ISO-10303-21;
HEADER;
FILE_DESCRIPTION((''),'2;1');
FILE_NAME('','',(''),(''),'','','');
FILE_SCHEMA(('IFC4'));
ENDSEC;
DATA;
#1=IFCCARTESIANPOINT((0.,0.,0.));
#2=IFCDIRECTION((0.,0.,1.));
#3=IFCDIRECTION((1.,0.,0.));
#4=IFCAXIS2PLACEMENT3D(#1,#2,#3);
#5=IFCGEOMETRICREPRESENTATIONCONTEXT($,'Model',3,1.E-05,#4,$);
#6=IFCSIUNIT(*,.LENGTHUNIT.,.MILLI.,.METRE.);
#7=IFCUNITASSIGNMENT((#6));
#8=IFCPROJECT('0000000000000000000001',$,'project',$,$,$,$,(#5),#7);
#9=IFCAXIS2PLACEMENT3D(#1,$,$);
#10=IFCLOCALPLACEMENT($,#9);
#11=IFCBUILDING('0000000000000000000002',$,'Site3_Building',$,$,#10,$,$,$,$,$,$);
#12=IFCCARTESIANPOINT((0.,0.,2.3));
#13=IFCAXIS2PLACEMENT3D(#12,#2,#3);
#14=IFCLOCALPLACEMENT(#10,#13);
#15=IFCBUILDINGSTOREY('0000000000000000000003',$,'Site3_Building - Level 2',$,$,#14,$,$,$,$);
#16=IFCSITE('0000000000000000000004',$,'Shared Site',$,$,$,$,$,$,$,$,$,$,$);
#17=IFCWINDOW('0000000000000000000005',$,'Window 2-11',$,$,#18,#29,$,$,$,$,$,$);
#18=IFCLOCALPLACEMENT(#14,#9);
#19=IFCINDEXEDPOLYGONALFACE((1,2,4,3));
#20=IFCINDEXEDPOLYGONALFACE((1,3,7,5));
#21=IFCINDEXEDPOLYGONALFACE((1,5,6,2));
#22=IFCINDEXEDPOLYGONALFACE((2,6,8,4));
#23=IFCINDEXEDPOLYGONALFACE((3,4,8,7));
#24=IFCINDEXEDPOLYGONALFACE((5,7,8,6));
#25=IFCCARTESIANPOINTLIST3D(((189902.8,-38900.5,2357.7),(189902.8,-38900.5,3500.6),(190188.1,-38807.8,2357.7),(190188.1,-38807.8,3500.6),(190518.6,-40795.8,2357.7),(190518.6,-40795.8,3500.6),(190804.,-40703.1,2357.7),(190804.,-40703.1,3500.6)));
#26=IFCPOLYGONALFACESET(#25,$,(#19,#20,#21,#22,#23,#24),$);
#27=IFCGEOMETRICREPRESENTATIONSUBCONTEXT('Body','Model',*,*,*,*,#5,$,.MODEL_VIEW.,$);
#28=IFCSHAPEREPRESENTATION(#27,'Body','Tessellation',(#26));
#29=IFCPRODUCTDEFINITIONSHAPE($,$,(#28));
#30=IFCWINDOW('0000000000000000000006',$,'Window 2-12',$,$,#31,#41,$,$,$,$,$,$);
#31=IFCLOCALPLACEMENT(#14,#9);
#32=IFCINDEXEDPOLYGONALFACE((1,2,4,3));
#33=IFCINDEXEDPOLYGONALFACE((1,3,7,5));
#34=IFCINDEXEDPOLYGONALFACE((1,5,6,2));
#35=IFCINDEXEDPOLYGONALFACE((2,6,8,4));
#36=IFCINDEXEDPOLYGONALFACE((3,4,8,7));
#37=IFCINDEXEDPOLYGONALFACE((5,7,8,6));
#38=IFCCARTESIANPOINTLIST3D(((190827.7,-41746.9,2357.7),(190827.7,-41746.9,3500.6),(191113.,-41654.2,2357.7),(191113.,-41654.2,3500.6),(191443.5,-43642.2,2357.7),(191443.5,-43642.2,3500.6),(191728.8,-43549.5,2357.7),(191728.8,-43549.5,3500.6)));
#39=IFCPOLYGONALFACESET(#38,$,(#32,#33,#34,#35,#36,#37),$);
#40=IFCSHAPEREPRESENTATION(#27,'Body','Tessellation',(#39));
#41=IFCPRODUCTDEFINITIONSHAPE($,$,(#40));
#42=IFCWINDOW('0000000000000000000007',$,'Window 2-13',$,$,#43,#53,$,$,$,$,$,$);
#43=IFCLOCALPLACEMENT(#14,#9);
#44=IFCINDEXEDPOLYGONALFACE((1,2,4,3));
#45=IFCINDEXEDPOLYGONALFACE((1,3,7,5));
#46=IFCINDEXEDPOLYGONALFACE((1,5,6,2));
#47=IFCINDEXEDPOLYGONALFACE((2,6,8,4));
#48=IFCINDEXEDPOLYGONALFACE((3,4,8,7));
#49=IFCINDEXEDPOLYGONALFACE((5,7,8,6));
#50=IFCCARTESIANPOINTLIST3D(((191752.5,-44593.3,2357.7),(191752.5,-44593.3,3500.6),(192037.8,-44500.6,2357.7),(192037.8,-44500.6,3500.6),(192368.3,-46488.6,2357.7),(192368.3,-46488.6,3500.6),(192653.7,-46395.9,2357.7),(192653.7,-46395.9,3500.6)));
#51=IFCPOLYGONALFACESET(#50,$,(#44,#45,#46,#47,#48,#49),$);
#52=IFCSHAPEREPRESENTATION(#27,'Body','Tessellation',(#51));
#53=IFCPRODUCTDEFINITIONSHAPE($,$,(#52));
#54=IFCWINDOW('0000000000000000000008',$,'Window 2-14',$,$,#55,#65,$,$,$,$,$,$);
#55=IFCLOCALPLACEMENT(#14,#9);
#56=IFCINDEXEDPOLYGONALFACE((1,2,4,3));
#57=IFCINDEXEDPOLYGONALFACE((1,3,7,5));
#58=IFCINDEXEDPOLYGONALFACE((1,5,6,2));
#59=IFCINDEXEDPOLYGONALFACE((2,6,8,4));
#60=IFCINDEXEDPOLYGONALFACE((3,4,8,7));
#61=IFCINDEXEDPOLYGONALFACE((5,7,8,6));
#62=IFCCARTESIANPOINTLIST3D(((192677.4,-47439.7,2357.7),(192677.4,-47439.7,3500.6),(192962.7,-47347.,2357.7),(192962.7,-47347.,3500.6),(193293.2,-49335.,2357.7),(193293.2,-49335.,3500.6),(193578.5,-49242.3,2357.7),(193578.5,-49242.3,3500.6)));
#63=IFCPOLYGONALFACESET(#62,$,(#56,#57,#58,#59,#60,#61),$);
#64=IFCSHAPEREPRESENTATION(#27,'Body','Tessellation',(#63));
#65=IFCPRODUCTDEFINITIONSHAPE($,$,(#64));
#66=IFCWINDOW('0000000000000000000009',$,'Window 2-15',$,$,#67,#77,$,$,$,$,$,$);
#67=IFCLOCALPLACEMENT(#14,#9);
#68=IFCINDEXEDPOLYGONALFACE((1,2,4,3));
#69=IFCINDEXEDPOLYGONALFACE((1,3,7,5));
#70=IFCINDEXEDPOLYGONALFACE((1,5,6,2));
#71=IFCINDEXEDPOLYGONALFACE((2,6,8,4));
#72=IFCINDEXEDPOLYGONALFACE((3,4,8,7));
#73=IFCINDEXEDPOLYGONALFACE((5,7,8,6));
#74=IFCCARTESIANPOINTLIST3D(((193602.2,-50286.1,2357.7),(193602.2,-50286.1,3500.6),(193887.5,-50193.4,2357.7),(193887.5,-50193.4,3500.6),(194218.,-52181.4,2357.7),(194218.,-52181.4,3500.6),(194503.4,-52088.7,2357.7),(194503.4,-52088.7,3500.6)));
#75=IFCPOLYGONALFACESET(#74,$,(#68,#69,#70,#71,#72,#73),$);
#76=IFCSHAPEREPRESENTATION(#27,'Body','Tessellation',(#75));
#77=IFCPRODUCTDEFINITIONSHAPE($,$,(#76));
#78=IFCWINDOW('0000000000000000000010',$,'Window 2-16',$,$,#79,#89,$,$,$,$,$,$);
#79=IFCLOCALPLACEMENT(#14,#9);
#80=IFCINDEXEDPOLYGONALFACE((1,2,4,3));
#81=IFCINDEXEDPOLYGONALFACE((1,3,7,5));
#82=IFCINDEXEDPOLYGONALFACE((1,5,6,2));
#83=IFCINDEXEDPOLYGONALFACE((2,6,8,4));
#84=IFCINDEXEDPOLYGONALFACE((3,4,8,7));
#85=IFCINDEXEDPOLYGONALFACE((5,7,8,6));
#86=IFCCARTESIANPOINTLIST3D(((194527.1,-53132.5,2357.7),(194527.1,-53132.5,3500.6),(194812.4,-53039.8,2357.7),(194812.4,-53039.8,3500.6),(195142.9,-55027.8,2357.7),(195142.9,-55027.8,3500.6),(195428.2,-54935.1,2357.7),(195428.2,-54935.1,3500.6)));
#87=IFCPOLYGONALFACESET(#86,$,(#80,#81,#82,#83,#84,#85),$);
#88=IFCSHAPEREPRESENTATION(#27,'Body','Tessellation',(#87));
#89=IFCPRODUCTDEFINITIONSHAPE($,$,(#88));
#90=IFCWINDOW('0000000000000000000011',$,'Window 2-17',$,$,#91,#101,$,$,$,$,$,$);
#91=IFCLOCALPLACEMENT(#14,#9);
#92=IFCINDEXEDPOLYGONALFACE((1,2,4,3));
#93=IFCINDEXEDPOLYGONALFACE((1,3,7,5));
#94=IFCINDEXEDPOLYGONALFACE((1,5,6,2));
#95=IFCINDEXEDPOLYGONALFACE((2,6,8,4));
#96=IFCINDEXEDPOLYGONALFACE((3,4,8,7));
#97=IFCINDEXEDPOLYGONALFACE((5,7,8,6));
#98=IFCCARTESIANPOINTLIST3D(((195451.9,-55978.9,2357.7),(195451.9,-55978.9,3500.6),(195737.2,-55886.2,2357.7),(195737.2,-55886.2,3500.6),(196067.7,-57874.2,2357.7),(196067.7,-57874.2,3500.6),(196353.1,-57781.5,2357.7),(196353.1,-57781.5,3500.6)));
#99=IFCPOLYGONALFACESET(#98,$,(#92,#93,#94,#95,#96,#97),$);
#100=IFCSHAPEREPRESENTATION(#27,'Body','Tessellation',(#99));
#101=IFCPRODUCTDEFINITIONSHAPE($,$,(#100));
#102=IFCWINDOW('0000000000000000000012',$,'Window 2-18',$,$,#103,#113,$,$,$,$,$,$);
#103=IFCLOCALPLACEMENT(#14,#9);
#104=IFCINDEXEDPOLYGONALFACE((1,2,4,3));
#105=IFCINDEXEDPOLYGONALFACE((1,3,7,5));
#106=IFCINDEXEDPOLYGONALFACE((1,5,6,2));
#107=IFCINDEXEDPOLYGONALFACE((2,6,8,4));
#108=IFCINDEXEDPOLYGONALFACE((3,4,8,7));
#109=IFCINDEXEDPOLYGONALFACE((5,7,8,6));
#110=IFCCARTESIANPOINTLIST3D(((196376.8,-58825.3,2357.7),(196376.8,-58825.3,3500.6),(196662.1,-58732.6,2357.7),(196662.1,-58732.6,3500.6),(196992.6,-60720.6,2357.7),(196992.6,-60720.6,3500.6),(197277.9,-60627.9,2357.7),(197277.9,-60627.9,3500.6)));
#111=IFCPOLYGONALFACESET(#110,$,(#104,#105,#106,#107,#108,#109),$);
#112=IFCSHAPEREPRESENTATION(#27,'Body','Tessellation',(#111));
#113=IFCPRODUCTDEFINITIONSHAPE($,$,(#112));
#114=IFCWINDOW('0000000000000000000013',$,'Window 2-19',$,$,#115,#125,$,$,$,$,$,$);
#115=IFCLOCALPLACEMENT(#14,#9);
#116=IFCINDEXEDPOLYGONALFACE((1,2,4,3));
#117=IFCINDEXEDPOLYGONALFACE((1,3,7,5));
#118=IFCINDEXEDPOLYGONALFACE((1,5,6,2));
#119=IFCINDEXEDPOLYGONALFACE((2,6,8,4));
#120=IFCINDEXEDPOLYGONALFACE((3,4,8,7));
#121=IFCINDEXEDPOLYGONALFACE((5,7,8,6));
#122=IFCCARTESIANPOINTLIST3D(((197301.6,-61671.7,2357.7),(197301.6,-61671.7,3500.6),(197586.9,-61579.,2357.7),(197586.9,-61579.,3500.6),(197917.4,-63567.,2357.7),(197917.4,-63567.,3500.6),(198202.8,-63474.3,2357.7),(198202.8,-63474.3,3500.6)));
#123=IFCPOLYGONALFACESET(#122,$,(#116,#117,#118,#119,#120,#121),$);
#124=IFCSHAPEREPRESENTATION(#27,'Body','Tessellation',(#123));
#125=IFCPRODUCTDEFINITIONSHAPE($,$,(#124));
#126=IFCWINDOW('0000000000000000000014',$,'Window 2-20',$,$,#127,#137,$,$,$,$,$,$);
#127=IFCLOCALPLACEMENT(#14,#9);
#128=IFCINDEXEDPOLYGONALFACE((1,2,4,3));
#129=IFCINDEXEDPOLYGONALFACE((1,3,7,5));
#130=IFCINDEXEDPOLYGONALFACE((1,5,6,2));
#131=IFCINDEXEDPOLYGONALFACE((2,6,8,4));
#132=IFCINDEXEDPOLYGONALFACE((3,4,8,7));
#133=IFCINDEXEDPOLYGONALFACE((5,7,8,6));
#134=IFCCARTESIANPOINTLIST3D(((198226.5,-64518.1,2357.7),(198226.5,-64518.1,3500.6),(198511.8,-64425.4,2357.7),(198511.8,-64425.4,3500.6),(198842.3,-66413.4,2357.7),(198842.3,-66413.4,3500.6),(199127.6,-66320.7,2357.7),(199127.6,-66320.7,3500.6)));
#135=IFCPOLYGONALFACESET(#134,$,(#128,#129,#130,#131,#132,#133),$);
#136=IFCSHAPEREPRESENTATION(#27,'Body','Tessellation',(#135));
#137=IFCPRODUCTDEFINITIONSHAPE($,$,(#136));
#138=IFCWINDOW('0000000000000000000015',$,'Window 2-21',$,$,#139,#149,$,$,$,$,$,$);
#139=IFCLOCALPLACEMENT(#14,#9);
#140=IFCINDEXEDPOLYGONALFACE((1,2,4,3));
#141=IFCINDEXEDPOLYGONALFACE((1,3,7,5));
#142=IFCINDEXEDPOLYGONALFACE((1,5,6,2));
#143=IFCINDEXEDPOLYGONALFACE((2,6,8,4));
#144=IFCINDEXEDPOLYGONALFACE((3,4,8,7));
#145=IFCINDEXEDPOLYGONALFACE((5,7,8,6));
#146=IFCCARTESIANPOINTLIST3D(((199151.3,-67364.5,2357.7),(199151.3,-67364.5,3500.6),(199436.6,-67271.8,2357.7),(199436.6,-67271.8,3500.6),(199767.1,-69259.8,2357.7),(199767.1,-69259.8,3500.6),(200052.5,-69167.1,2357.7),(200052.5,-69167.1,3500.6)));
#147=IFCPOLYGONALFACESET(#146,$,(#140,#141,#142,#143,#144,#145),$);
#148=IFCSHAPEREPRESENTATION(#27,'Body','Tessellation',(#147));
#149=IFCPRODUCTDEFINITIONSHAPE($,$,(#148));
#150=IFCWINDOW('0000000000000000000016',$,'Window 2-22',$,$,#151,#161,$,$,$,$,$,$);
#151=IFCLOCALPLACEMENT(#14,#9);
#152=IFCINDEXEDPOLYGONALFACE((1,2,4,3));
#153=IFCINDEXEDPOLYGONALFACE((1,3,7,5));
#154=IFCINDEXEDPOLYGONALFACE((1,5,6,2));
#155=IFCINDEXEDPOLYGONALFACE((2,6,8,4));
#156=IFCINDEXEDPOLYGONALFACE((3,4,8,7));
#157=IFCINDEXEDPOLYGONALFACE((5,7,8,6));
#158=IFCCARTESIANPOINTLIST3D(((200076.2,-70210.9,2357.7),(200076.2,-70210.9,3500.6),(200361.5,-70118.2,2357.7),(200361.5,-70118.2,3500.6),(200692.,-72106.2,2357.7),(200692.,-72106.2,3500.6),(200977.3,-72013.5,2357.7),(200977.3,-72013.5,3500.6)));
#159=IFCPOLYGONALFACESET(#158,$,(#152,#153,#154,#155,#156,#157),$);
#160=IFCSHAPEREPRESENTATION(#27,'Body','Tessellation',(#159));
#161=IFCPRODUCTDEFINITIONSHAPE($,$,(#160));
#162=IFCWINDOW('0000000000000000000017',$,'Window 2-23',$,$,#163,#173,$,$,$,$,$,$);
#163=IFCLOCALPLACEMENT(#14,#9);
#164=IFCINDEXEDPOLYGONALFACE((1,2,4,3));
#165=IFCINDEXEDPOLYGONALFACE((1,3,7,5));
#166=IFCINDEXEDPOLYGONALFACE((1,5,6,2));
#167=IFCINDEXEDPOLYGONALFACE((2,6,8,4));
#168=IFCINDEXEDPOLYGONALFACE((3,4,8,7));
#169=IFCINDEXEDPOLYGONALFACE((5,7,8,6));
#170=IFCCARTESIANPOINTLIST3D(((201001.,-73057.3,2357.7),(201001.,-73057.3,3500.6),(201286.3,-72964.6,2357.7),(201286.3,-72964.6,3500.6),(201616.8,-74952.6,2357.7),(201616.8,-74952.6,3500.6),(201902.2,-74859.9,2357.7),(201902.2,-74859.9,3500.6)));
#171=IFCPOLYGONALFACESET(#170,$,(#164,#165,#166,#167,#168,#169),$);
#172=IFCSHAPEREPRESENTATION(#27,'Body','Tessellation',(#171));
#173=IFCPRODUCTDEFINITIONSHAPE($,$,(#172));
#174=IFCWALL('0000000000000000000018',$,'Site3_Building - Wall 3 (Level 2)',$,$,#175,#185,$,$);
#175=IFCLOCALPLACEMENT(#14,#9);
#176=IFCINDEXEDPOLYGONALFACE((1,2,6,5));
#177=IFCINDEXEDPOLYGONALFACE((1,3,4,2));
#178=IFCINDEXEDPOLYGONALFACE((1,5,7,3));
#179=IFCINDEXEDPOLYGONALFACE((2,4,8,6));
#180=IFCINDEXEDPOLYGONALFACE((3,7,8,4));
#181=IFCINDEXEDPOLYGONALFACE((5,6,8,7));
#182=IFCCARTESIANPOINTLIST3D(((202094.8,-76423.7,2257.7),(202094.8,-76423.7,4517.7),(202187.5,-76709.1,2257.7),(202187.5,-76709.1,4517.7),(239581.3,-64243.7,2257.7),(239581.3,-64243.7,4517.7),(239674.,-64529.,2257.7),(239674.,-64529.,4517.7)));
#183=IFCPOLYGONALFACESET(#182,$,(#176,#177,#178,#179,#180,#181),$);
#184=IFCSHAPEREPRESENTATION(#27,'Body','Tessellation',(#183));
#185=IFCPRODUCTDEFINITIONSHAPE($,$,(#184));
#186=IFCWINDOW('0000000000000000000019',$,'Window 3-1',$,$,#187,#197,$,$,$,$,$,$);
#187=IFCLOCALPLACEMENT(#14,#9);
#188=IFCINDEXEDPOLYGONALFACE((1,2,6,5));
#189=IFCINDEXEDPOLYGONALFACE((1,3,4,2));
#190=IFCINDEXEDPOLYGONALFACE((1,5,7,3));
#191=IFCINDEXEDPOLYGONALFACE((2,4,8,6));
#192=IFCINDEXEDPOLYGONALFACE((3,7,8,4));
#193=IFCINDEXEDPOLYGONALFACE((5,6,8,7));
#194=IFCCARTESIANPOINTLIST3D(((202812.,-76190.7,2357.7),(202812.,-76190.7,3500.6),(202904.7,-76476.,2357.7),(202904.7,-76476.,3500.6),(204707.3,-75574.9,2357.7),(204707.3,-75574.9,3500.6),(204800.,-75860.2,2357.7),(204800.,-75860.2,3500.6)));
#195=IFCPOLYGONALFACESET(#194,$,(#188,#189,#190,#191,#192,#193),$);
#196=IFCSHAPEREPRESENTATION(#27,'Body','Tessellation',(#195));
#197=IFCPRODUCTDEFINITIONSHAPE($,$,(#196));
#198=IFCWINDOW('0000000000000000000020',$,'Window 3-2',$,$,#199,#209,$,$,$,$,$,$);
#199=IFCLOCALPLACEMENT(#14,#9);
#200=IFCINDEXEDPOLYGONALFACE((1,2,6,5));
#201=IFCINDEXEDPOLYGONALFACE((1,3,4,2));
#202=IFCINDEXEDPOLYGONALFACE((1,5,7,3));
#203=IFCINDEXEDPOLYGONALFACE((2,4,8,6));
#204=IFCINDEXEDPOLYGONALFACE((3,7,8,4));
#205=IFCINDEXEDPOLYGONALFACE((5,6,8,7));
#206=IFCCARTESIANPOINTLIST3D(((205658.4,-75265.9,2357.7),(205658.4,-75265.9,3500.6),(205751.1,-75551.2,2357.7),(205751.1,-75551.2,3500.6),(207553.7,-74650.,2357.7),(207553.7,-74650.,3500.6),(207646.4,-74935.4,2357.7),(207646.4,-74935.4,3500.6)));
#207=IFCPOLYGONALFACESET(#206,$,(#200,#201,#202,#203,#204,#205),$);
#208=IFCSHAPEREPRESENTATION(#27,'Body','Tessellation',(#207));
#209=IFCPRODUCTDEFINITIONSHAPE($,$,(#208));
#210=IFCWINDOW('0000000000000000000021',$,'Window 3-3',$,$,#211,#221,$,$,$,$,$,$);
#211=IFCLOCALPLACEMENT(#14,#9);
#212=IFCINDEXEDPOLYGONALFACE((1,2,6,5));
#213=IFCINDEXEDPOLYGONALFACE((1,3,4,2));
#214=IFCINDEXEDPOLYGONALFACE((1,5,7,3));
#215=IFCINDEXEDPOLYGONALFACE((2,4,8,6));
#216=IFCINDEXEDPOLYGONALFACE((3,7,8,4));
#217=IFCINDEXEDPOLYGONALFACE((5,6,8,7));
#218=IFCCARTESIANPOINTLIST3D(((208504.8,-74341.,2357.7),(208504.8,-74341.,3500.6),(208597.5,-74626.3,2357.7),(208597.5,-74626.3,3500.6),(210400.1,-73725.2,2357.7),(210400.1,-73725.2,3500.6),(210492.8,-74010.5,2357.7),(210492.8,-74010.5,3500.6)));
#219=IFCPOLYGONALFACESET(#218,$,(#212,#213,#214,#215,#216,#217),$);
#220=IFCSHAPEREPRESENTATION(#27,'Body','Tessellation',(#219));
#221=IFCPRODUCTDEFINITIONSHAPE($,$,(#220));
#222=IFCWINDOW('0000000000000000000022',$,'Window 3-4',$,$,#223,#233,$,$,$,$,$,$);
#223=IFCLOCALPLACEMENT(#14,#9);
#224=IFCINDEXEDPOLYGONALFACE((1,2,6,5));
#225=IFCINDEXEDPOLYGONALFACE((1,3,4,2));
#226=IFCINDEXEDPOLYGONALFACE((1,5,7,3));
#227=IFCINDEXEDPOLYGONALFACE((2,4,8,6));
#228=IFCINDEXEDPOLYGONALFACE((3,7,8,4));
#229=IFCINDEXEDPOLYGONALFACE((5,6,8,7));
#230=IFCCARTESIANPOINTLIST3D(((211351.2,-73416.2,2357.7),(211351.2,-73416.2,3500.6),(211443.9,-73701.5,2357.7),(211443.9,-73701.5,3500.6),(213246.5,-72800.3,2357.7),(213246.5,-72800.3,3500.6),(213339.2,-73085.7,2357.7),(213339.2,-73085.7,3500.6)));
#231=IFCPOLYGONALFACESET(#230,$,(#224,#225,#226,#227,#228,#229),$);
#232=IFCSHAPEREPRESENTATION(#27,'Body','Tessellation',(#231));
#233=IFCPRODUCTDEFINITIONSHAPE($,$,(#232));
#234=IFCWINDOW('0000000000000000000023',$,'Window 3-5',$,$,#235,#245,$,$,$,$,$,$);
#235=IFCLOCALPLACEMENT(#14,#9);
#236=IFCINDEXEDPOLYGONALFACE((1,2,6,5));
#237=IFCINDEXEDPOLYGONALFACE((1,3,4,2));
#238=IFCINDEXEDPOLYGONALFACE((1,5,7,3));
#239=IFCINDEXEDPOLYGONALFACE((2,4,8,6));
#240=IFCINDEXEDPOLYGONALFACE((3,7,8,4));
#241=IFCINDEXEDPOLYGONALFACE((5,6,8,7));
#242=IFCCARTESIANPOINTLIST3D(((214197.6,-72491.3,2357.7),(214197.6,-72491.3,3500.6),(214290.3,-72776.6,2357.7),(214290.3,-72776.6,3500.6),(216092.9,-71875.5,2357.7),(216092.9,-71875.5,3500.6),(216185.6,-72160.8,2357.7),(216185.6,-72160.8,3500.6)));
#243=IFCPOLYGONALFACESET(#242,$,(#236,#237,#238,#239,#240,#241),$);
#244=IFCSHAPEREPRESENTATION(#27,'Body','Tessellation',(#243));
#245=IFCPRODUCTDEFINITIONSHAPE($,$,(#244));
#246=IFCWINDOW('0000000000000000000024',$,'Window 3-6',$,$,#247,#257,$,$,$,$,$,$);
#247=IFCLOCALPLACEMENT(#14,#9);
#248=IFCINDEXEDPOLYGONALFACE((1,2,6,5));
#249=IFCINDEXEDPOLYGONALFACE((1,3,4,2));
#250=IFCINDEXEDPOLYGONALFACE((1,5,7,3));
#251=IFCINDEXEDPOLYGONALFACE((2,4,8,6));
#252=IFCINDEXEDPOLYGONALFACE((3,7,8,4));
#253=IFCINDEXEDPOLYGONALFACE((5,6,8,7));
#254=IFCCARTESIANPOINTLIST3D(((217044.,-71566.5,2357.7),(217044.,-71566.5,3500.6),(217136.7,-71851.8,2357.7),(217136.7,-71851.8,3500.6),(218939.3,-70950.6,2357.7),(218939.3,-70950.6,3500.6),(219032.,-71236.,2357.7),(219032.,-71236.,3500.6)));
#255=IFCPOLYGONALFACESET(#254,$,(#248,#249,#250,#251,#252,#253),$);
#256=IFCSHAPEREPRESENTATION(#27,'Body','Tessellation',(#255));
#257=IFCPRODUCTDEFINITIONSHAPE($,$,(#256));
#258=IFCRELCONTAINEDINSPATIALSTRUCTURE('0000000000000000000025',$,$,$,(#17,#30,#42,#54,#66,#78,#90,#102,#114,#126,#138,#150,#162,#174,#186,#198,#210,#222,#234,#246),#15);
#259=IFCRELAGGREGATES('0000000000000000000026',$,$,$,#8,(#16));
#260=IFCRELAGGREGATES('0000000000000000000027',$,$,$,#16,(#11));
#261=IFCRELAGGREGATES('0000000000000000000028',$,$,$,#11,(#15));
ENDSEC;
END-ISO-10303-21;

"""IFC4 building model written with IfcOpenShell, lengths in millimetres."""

from ifc_helpers import new_model, si_unit, frame, origin, origin_with_axes, place, context, subcontext, project, spatial, indexed_curve, outline, extrude, element, save


model = new_model("IFC4")

# Units and contexts
model_context = context("Model", 3, precision=1e-05, world=origin_with_axes())
body_context = subcontext(model_context, "Body", "Model", "MODEL_VIEW")
ifc_project = project(units=[si_unit("LENGTHUNIT", "METRE", prefix="MILLI")], contexts=[model_context])

# Site, building, storey
site = spatial("IfcSite", under=ifc_project, Name="Shared Site")
building_placement = place(None, origin())
building = spatial("IfcBuilding", under=site, at=building_placement, Name="Site3_Building")
storey_placement = place(building_placement, frame((0.0, 0.0, 2.3), z_axis=(0.0, 0.0, 1.0), x_axis=(1.0, 0.0, 0.0)))
storey = spatial("IfcBuildingStorey", under=building, at=storey_placement, Name="Site3_Building - Level 2")

# Windows
for number, where, z_axis, x_axis, name in (
    (1, (189902.8, -38900.5, 2357.7), (0.0, 0.0, 1.0), (0.309017, -0.951057, 0.0), "Window 2-11"),
    (2, (190827.7, -41746.9, 2357.7), (0.0, 0.0, 1.0), (0.309017, -0.951057, 0.0), "Window 2-12"),
    (3, (191752.5, -44593.3, 2357.7), (0.0, 0.0, 1.0), (0.309017, -0.951057, 0.0), "Window 2-13"),
    (4, (192677.4, -47439.7, 2357.7), (0.0, 0.0, 1.0), (0.309017, -0.951057, 0.0), "Window 2-14"),
    (5, (193602.2, -50286.1, 2357.7), (0.0, 0.0, 1.0), (0.309017, -0.951057, 0.0), "Window 2-15"),
    (6, (194527.1, -53132.5, 2357.7), (0.0, 0.0, 1.0), (0.309017, -0.951057, 0.0), "Window 2-16"),
    (7, (195451.9, -55978.9, 2357.7), (0.0, 0.0, 1.0), (0.309017, -0.951057, 0.0), "Window 2-17"),
    (8, (196376.8, -58825.3, 2357.7), (0.0, 0.0, 1.0), (0.309017, -0.951057, 0.0), "Window 2-18"),
    (9, (197301.6, -61671.7, 2357.7), (0.0, 0.0, 1.0), (0.309017, -0.951057, 0.0), "Window 2-19"),
    (10, (198226.5, -64518.1, 2357.7), (0.0, 0.0, 1.0), (0.309017, -0.951057, 0.0), "Window 2-20"),
    (11, (199151.3, -67364.5, 2357.7), (0.0, 0.0, 1.0), (0.309017, -0.951057, 0.0), "Window 2-21"),
    (12, (200076.2, -70210.9, 2357.7), (0.0, 0.0, 1.0), (0.309017, -0.951057, 0.0), "Window 2-22"),
    (13, (201001.0, -73057.3, 2357.7), (0.0, 0.0, 1.0), (0.309017, -0.951057, 0.0), "Window 2-23"),
):
    element("IfcWindow", number, at=place(storey_placement, frame(where, z_axis=z_axis, x_axis=x_axis)), inside=storey, Name=name, context=body_context, shape_type="SweptSolid", body=[
        extrude(outline(indexed_curve([(0.0, 0.0), (0.0, 300.0), (1992.9, 300.0), (1992.9, 0.0), (0.0, 0.0)], self_intersect=False)), origin_with_axes(), (0.0, 0.0, 1.0), 1142.8),
    ])

# Wall
wall_1_placement = place(storey_placement, frame((202187.5, -76709.1, 2257.7), z_axis=(0.0, 0.0, 1.0), x_axis=(0.951057, 0.309017, 0.0)))
element("IfcWall", 14, at=wall_1_placement, inside=storey, Name="Site3_Building - Wall 3 (Level 2)", context=body_context, shape_type="SweptSolid", body=[
    extrude(outline(indexed_curve([(0.0, 0.0), (0.0, 300.0), (39415.5, 300.0), (39415.5, 0.0), (0.0, 0.0)], self_intersect=False)), origin_with_axes(), (0.0, 0.0, 1.0), 2260.0),
])

# Windows
for number, where, z_axis, x_axis, name in (
    (15, (202904.7, -76476.0, 2357.7), (0.0, 0.0, 1.0), (0.951057, 0.309017, 0.0), "Window 3-1"),
    (16, (205751.1, -75551.2, 2357.7), (0.0, 0.0, 1.0), (0.951057, 0.309017, 0.0), "Window 3-2"),
    (17, (208597.5, -74626.3, 2357.7), (0.0, 0.0, 1.0), (0.951057, 0.309017, 0.0), "Window 3-3"),
    (18, (211443.9, -73701.5, 2357.7), (0.0, 0.0, 1.0), (0.951057, 0.309017, 0.0), "Window 3-4"),
    (19, (214290.3, -72776.6, 2357.7), (0.0, 0.0, 1.0), (0.951057, 0.309017, 0.0), "Window 3-5"),
    (20, (217136.7, -71851.8, 2357.7), (0.0, 0.0, 1.0), (0.951057, 0.309017, 0.0), "Window 3-6"),
):
    element("IfcWindow", number, at=place(storey_placement, frame(where, z_axis=z_axis, x_axis=x_axis)), inside=storey, Name=name, context=body_context, shape_type="SweptSolid", body=[
        extrude(outline(indexed_curve([(0.0, 0.0), (0.0, 300.0), (1992.9, 300.0), (1992.9, 0.0), (0.0, 0.0)], self_intersect=False)), origin_with_axes(), (0.0, 0.0, 1.0), 1142.8),
    ])

save(model, "model.ifc")
